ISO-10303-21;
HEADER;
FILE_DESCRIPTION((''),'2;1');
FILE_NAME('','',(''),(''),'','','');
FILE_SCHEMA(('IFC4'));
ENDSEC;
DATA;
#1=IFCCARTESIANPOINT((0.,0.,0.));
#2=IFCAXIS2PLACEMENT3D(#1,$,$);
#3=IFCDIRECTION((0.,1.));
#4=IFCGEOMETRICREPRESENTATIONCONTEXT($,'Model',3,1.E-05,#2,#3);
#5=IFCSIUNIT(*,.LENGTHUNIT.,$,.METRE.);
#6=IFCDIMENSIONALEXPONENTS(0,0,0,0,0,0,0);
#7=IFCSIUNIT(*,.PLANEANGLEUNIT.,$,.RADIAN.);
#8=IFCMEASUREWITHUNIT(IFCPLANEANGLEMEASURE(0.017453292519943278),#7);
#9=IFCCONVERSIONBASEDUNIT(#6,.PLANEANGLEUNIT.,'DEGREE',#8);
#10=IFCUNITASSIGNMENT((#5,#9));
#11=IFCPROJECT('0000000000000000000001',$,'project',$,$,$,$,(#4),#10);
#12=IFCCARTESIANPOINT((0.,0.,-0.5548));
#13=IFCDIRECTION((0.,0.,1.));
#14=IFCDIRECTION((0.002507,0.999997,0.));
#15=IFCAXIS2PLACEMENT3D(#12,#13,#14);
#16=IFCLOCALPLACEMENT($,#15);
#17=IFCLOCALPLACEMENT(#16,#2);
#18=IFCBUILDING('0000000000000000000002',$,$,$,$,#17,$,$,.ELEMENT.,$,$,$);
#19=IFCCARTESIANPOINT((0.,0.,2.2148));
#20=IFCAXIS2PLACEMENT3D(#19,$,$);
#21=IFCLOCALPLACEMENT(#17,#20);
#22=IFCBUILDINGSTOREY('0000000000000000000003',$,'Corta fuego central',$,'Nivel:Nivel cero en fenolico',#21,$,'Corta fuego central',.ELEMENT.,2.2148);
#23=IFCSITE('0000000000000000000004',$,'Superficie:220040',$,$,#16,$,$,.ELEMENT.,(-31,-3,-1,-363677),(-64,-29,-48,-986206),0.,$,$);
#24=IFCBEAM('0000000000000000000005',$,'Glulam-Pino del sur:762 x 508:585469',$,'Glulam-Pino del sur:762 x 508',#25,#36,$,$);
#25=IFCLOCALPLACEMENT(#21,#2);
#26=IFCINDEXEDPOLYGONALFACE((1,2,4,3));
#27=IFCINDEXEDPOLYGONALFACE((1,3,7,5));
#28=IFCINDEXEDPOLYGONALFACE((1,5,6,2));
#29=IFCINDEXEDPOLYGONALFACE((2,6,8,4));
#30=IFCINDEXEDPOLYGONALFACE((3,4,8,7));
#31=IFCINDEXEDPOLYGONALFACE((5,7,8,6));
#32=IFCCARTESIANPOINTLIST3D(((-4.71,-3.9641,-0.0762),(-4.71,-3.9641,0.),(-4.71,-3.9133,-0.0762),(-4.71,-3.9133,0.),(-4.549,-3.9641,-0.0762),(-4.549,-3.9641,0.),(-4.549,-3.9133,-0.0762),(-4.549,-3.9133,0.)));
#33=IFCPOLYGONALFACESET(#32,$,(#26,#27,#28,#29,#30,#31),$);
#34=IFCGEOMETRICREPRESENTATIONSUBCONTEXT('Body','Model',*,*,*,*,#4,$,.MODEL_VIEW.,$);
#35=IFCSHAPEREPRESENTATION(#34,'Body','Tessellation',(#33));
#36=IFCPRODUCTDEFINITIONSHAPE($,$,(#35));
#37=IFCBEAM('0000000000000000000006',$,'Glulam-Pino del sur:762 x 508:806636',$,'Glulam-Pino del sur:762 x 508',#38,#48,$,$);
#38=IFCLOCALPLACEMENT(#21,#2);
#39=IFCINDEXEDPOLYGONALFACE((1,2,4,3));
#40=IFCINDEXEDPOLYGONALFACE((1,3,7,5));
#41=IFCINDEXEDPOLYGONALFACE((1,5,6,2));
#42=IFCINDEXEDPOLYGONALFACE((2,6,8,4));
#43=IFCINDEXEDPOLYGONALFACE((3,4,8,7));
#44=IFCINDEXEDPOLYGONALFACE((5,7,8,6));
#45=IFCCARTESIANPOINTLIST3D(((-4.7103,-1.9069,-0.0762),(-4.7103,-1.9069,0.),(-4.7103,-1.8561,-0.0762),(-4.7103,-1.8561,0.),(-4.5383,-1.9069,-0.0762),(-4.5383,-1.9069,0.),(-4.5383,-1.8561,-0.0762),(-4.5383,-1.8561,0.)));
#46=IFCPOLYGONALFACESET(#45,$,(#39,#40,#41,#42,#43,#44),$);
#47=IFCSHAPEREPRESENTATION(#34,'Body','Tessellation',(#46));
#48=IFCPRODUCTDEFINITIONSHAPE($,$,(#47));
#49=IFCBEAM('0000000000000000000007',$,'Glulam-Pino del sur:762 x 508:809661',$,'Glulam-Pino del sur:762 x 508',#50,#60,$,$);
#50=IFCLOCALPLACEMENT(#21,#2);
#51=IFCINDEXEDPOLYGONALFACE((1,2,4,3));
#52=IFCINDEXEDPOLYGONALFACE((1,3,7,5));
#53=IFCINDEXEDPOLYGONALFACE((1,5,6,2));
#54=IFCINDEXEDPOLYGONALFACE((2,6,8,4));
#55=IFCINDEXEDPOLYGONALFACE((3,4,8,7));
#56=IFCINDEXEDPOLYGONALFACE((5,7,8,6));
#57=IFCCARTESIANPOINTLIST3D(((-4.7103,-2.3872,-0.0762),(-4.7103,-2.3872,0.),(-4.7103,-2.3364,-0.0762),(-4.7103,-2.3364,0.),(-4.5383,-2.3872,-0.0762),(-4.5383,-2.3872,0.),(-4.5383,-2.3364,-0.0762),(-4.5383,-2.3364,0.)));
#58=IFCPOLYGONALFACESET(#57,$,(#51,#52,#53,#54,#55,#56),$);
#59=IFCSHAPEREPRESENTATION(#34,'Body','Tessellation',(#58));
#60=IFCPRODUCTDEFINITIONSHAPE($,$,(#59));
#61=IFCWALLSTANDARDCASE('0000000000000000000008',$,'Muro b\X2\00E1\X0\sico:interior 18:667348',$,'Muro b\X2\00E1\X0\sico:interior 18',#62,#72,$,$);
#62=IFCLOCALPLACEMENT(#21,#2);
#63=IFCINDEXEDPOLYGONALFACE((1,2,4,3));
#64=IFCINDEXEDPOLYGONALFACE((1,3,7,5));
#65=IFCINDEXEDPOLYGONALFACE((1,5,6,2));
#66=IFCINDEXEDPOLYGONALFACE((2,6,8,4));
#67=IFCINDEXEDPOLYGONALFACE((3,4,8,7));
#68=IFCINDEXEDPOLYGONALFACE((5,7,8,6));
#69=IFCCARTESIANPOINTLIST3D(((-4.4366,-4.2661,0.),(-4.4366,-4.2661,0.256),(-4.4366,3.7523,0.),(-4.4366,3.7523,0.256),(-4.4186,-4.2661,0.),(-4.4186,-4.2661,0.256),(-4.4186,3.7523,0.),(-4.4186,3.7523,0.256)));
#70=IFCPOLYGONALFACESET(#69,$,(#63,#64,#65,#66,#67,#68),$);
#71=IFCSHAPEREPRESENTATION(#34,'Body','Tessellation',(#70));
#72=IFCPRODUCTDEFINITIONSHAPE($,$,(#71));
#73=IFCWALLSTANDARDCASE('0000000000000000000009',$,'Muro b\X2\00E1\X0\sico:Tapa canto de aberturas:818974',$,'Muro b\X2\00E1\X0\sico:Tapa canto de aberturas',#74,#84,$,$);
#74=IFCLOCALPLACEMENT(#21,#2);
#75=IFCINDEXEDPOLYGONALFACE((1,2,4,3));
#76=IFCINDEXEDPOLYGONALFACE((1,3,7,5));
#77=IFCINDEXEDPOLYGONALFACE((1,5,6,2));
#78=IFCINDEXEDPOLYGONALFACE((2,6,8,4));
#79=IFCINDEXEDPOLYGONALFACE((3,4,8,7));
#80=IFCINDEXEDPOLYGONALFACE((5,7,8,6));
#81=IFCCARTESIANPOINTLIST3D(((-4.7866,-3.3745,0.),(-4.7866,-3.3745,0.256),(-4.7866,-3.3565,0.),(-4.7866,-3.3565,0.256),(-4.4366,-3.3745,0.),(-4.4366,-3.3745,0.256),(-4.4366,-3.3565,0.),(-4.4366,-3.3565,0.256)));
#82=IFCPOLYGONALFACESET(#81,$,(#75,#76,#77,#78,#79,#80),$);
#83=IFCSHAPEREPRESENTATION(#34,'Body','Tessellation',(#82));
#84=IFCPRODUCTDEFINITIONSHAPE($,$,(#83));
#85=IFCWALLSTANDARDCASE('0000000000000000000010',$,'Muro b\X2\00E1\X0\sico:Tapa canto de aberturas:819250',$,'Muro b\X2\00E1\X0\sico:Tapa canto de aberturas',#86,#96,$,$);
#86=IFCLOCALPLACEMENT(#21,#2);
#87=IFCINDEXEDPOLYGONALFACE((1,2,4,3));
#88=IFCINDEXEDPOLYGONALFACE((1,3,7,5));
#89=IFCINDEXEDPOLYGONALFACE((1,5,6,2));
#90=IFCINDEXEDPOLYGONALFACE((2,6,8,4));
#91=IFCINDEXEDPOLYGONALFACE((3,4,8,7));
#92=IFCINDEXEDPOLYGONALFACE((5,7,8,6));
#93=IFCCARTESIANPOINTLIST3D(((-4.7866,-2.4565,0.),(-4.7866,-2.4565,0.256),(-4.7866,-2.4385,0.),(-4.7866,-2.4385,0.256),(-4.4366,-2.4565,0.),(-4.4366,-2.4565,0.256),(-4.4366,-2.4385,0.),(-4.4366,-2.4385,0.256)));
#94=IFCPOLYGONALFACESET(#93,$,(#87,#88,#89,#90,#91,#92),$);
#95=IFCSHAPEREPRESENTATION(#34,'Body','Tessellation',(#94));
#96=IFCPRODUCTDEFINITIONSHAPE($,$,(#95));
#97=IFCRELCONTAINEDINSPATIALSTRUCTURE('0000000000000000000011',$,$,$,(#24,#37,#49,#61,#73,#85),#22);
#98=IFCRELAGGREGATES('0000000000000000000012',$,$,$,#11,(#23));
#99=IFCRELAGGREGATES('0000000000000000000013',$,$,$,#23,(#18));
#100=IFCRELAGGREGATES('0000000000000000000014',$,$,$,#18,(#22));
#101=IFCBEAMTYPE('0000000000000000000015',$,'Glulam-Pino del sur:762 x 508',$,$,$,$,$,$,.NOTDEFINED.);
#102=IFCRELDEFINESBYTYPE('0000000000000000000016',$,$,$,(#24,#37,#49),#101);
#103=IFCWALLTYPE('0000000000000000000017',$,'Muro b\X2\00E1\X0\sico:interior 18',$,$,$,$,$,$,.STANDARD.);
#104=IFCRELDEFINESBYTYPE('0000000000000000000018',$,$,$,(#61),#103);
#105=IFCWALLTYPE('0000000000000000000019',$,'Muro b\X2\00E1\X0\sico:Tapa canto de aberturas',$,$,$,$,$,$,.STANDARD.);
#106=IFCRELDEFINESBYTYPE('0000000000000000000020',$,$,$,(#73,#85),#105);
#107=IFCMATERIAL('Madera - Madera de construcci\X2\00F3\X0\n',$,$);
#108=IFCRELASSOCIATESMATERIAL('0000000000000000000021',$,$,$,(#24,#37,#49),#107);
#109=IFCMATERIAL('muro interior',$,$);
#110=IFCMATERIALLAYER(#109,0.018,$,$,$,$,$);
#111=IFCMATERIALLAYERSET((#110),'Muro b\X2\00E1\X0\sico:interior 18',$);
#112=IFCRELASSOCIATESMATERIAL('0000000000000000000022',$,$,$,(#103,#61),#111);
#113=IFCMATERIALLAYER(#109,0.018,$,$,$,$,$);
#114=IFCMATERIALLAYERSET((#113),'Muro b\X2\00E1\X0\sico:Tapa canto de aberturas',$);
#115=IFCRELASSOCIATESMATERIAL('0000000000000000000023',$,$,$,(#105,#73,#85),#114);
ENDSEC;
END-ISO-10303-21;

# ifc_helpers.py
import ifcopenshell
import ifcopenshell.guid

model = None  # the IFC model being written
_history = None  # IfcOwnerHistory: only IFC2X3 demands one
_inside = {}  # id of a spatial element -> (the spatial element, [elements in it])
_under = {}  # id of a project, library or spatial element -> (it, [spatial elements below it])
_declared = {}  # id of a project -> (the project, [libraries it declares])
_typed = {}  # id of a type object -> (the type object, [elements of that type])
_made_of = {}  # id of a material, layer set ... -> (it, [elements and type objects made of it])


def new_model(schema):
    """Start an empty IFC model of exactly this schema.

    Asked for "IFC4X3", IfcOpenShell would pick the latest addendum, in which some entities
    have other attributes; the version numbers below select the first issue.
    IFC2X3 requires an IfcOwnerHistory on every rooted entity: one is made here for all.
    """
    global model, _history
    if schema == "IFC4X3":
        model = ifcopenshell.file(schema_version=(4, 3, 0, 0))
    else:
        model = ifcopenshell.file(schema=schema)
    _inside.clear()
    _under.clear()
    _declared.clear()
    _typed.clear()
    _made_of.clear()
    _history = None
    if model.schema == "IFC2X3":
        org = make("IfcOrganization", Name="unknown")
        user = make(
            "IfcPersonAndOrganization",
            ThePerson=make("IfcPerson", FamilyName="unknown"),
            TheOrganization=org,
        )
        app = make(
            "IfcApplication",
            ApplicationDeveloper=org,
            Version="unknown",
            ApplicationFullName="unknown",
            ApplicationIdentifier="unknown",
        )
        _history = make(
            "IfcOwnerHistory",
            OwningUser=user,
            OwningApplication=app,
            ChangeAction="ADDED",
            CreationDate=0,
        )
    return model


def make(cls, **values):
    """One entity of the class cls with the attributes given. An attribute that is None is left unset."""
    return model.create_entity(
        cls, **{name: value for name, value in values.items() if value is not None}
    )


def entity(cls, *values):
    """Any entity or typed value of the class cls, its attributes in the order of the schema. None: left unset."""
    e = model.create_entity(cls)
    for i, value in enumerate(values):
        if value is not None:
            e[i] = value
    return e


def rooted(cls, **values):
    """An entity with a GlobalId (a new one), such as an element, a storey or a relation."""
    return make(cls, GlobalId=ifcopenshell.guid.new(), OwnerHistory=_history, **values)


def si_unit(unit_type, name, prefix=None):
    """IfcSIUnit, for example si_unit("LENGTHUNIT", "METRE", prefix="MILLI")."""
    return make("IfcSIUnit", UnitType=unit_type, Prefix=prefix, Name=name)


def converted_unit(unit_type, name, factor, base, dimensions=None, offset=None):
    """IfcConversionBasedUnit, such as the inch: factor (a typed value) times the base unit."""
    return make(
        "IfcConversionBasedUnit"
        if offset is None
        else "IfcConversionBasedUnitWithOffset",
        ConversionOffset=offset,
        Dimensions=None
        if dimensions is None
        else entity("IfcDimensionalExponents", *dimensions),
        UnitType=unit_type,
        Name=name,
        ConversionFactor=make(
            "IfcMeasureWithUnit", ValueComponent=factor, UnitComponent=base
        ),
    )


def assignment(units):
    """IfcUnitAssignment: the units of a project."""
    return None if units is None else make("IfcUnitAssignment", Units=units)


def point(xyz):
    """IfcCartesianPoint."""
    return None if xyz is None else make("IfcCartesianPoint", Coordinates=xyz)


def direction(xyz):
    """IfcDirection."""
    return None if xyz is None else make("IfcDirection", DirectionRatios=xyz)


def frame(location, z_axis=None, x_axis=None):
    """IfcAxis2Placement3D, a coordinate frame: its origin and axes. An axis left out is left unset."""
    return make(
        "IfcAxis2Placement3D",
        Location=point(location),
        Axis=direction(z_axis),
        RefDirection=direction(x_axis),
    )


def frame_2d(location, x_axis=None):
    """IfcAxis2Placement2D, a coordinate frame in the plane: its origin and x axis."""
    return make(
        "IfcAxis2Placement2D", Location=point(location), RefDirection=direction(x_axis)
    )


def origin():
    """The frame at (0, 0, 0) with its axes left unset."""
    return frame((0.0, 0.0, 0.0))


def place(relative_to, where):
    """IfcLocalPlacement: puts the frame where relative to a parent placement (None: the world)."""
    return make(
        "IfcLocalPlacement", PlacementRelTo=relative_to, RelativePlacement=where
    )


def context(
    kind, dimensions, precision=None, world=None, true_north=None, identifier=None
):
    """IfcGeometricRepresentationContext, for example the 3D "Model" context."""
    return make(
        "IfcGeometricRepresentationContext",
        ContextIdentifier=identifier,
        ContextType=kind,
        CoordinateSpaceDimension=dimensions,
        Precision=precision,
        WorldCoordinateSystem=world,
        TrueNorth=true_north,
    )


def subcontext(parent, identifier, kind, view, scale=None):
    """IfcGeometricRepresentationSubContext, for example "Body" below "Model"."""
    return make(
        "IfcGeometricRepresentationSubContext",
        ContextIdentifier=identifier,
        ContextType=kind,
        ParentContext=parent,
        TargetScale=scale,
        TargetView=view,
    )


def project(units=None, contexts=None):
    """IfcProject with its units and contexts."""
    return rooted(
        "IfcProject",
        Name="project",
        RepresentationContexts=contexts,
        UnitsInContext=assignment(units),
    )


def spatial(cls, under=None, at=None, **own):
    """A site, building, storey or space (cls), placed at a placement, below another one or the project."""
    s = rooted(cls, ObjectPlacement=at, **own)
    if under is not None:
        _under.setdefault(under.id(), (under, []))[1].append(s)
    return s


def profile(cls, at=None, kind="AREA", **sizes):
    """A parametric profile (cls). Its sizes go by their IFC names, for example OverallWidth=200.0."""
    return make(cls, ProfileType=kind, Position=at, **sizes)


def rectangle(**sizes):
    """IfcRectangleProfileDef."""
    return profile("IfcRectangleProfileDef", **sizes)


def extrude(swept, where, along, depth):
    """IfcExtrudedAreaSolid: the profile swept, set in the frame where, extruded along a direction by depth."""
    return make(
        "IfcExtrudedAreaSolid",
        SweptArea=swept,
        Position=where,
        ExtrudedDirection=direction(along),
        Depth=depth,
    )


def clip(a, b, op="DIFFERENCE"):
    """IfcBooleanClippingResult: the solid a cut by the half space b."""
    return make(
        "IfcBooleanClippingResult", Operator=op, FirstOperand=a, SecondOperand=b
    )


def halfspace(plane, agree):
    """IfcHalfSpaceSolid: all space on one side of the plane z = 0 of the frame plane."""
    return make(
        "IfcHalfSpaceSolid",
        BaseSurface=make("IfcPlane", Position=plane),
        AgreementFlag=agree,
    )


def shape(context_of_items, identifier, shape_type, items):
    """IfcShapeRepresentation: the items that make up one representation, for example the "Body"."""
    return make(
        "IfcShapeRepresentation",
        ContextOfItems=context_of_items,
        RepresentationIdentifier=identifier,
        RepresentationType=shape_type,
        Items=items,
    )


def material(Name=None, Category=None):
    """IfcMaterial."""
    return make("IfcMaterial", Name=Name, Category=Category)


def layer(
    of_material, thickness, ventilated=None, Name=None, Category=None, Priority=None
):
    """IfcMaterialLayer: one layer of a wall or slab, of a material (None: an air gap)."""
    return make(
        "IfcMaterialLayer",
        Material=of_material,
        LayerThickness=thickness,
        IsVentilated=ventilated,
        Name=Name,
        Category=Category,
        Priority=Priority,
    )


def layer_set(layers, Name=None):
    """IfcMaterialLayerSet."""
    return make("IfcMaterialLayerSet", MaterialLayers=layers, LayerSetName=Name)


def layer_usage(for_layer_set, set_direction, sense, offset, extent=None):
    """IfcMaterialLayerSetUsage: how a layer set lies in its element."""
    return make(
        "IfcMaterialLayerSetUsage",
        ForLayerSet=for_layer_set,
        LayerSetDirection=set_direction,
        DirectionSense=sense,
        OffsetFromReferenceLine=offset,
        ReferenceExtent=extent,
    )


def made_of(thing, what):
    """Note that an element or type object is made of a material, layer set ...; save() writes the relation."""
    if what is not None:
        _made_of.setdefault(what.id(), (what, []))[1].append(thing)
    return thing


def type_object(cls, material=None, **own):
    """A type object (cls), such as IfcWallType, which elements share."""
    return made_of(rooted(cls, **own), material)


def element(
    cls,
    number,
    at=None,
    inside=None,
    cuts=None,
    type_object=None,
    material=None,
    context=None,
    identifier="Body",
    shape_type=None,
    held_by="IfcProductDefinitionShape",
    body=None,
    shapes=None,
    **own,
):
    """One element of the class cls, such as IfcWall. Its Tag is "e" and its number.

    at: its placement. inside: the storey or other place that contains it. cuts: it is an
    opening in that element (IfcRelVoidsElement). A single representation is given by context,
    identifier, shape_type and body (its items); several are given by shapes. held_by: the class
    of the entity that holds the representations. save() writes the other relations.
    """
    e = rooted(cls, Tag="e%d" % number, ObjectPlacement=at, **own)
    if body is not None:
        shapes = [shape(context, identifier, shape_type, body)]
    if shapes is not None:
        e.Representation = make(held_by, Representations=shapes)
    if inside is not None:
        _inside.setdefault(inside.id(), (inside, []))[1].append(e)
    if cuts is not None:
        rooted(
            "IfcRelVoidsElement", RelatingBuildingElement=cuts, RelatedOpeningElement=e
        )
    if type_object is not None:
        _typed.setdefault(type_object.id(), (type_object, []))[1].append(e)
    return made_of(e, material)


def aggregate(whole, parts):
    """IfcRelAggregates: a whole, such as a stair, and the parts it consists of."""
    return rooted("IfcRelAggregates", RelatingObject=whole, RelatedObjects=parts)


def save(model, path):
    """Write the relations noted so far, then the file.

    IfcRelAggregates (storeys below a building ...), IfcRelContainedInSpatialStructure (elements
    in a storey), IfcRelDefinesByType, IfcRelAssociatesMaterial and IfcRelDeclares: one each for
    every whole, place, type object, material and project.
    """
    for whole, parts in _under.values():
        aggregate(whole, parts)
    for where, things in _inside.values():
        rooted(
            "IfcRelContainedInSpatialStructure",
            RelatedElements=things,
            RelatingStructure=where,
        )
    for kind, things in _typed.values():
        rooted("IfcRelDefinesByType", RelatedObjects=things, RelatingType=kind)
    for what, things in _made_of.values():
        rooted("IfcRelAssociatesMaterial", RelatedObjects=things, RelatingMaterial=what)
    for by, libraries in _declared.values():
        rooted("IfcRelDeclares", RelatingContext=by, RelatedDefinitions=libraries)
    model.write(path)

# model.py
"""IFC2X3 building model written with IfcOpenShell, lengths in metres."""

from ifc_helpers import new_model, entity, si_unit, converted_unit, direction, frame, frame_2d, origin, place, context, subcontext, project, spatial, rectangle, extrude, clip, halfspace, material, layer, layer_set, layer_usage, type_object, element, save


model = new_model("IFC2X3")

# Units and contexts
model_context = context("Model", 3, precision=1e-05, world=origin(), true_north=direction((0.0, 1.0)))
body_context = subcontext(model_context, "Body", "Model", "MODEL_VIEW")
ifc_project = project(units=[si_unit("LENGTHUNIT", "METRE"), converted_unit("PLANEANGLEUNIT", "DEGREE", entity("IfcPlaneAngleMeasure", 0.017453292519943278), si_unit("PLANEANGLEUNIT", "RADIAN"), dimensions=[0, 0, 0, 0, 0, 0, 0])], contexts=[model_context])

# Site, building, storey
site_placement = place(None, frame((0.0, 0.0, -0.5548), z_axis=(0.0, 0.0, 1.0), x_axis=(0.002507, 0.999997, 0.0)))
site = spatial("IfcSite", under=ifc_project, at=site_placement, Name="Superficie:220040", CompositionType="ELEMENT", RefLatitude=(-31, -3, -1, -363677), RefLongitude=(-64, -29, -48, -986206), RefElevation=0.0)
building_placement = place(site_placement, origin())
building = spatial("IfcBuilding", under=site, at=building_placement, CompositionType="ELEMENT")
storey_placement = place(building_placement, frame((0.0, 0.0, 2.2148)))
storey = spatial("IfcBuildingStorey", under=building, at=storey_placement, Name="Corta fuego central", ObjectType="Nivel:Nivel cero en fenolico", LongName="Corta fuego central", CompositionType="ELEMENT", Elevation=2.2148)

# Shared definitions
ifc_material_1 = material(Name="Madera - Madera de construcción")

# Beams
beam_type_1 = type_object("IfcBeamType", Name="Glulam-Pino del sur:762 x 508", PredefinedType="NOTDEFINED")
beam_1_placement = place(storey_placement, frame((-4.7479, -3.9387, 0.0)))
element("IfcBeam", 1, at=beam_1_placement, inside=storey, type_object=beam_type_1, material=ifc_material_1, Name="Glulam-Pino del sur:762 x 508:585469", ObjectType="Glulam-Pino del sur:762 x 508", context=body_context, shape_type="SweptSolid", body=[
    extrude(rectangle(XDim=0.0762, YDim=0.0508, at=frame_2d((0.0, 0.0), x_axis=(1.0, 0.0))), frame((0.0379, 0.0, -0.0381), z_axis=(1.0, 0.0, 0.0), x_axis=(0.0, 0.0, -1.0)), (0.0, 0.0, 1.0), 0.161),
])
beam_2_placement = place(storey_placement, frame((-4.7104, -1.8815, 0.0)))
element("IfcBeam", 2, at=beam_2_placement, inside=storey, type_object=beam_type_1, material=ifc_material_1, Name="Glulam-Pino del sur:762 x 508:806636", ObjectType="Glulam-Pino del sur:762 x 508", context=body_context, shape_type="SweptSolid", body=[
    extrude(rectangle(XDim=0.0762, YDim=0.0508, at=frame_2d((0.0, 0.0), x_axis=(1.0, 0.0))), frame((0.0001, 0.0, -0.0381), z_axis=(1.0, 0.0, 0.0), x_axis=(0.0, 0.0, -1.0)), (0.0, 0.0, 1.0), 0.172),
])
beam_3_placement = place(storey_placement, frame((-4.7104, -2.3618, 0.0)))
element("IfcBeam", 3, at=beam_3_placement, inside=storey, type_object=beam_type_1, material=ifc_material_1, Name="Glulam-Pino del sur:762 x 508:809661", ObjectType="Glulam-Pino del sur:762 x 508", context=body_context, shape_type="SweptSolid", body=[
    extrude(rectangle(XDim=0.0762, YDim=0.0508, at=frame_2d((0.0, 0.0), x_axis=(1.0, 0.0))), frame((0.0001, 0.0, -0.0381), z_axis=(1.0, 0.0, 0.0), x_axis=(0.0, 0.0, -1.0)), (0.0, 0.0, 1.0), 0.172),
])

# Walls
ifc_material_2 = material(Name="muro interior")
ifc_layer_1 = layer(ifc_material_2, 0.018)
ifc_layer_set_1 = layer_set([ifc_layer_1], Name="Muro básico:interior 18")
ifc_layer_usage_1 = layer_usage(ifc_layer_set_1, "AXIS2", "NEGATIVE", 0.009)
wall_type_1 = type_object("IfcWallType", Name="Muro básico:interior 18", PredefinedType="STANDARD", material=ifc_layer_set_1)
wall_1_placement = place(storey_placement, frame((-4.4276, -4.2661, 0.0), z_axis=(0.0, 0.0, 1.0), x_axis=(0.0, 1.0, 0.0)))
element("IfcWallStandardCase", 4, at=wall_1_placement, inside=storey, type_object=wall_type_1, material=ifc_layer_usage_1, Name="Muro básico:interior 18:667348", ObjectType="Muro básico:interior 18", context=body_context, shape_type="Clipping", body=[
    clip(extrude(rectangle(XDim=8.0184, YDim=0.018, at=frame_2d((4.0092, 0.0), x_axis=(-1.0, 0.0))), origin(), (0.0, 0.0, 1.0), 0.256), halfspace(frame((0.0, 0.0, -2.164)), True)),
])
ifc_layer_2 = layer(ifc_material_2, 0.018)
ifc_layer_set_2 = layer_set([ifc_layer_2], Name="Muro básico:Tapa canto de aberturas")
ifc_layer_usage_2 = layer_usage(ifc_layer_set_2, "AXIS2", "POSITIVE", -0.009)
wall_type_2 = type_object("IfcWallType", Name="Muro básico:Tapa canto de aberturas", PredefinedType="STANDARD", material=ifc_layer_set_2)
wall_2_placement = place(storey_placement, frame((-4.7866, -3.3655, 0.0)))
element("IfcWallStandardCase", 5, at=wall_2_placement, inside=storey, type_object=wall_type_2, material=ifc_layer_usage_2, Name="Muro básico:Tapa canto de aberturas:818974", ObjectType="Muro básico:Tapa canto de aberturas", context=body_context, shape_type="Clipping", body=[
    clip(extrude(rectangle(XDim=0.35, YDim=0.018, at=frame_2d((0.175, 0.0), x_axis=(-1.0, 0.0))), origin(), (0.0, 0.0, 1.0), 0.256), halfspace(frame((0.0, 0.0, -1.3348)), True)),
])
ifc_layer_usage_3 = layer_usage(ifc_layer_set_2, "AXIS2", "NEGATIVE", 0.009)
wall_3_placement = place(storey_placement, frame((-4.7866, -2.4475, 0.0)))
element("IfcWallStandardCase", 6, at=wall_3_placement, inside=storey, type_object=wall_type_2, material=ifc_layer_usage_3, Name="Muro básico:Tapa canto de aberturas:819250", ObjectType="Muro básico:Tapa canto de aberturas", context=body_context, shape_type="Clipping", body=[
    clip(extrude(rectangle(XDim=0.35, YDim=0.018, at=frame_2d((0.175, 0.0), x_axis=(-1.0, 0.0))), origin(), (0.0, 0.0, 1.0), 0.256), halfspace(frame((0.0, 0.0, -1.3348)), True)),
])

save(model, "model.ifc")
